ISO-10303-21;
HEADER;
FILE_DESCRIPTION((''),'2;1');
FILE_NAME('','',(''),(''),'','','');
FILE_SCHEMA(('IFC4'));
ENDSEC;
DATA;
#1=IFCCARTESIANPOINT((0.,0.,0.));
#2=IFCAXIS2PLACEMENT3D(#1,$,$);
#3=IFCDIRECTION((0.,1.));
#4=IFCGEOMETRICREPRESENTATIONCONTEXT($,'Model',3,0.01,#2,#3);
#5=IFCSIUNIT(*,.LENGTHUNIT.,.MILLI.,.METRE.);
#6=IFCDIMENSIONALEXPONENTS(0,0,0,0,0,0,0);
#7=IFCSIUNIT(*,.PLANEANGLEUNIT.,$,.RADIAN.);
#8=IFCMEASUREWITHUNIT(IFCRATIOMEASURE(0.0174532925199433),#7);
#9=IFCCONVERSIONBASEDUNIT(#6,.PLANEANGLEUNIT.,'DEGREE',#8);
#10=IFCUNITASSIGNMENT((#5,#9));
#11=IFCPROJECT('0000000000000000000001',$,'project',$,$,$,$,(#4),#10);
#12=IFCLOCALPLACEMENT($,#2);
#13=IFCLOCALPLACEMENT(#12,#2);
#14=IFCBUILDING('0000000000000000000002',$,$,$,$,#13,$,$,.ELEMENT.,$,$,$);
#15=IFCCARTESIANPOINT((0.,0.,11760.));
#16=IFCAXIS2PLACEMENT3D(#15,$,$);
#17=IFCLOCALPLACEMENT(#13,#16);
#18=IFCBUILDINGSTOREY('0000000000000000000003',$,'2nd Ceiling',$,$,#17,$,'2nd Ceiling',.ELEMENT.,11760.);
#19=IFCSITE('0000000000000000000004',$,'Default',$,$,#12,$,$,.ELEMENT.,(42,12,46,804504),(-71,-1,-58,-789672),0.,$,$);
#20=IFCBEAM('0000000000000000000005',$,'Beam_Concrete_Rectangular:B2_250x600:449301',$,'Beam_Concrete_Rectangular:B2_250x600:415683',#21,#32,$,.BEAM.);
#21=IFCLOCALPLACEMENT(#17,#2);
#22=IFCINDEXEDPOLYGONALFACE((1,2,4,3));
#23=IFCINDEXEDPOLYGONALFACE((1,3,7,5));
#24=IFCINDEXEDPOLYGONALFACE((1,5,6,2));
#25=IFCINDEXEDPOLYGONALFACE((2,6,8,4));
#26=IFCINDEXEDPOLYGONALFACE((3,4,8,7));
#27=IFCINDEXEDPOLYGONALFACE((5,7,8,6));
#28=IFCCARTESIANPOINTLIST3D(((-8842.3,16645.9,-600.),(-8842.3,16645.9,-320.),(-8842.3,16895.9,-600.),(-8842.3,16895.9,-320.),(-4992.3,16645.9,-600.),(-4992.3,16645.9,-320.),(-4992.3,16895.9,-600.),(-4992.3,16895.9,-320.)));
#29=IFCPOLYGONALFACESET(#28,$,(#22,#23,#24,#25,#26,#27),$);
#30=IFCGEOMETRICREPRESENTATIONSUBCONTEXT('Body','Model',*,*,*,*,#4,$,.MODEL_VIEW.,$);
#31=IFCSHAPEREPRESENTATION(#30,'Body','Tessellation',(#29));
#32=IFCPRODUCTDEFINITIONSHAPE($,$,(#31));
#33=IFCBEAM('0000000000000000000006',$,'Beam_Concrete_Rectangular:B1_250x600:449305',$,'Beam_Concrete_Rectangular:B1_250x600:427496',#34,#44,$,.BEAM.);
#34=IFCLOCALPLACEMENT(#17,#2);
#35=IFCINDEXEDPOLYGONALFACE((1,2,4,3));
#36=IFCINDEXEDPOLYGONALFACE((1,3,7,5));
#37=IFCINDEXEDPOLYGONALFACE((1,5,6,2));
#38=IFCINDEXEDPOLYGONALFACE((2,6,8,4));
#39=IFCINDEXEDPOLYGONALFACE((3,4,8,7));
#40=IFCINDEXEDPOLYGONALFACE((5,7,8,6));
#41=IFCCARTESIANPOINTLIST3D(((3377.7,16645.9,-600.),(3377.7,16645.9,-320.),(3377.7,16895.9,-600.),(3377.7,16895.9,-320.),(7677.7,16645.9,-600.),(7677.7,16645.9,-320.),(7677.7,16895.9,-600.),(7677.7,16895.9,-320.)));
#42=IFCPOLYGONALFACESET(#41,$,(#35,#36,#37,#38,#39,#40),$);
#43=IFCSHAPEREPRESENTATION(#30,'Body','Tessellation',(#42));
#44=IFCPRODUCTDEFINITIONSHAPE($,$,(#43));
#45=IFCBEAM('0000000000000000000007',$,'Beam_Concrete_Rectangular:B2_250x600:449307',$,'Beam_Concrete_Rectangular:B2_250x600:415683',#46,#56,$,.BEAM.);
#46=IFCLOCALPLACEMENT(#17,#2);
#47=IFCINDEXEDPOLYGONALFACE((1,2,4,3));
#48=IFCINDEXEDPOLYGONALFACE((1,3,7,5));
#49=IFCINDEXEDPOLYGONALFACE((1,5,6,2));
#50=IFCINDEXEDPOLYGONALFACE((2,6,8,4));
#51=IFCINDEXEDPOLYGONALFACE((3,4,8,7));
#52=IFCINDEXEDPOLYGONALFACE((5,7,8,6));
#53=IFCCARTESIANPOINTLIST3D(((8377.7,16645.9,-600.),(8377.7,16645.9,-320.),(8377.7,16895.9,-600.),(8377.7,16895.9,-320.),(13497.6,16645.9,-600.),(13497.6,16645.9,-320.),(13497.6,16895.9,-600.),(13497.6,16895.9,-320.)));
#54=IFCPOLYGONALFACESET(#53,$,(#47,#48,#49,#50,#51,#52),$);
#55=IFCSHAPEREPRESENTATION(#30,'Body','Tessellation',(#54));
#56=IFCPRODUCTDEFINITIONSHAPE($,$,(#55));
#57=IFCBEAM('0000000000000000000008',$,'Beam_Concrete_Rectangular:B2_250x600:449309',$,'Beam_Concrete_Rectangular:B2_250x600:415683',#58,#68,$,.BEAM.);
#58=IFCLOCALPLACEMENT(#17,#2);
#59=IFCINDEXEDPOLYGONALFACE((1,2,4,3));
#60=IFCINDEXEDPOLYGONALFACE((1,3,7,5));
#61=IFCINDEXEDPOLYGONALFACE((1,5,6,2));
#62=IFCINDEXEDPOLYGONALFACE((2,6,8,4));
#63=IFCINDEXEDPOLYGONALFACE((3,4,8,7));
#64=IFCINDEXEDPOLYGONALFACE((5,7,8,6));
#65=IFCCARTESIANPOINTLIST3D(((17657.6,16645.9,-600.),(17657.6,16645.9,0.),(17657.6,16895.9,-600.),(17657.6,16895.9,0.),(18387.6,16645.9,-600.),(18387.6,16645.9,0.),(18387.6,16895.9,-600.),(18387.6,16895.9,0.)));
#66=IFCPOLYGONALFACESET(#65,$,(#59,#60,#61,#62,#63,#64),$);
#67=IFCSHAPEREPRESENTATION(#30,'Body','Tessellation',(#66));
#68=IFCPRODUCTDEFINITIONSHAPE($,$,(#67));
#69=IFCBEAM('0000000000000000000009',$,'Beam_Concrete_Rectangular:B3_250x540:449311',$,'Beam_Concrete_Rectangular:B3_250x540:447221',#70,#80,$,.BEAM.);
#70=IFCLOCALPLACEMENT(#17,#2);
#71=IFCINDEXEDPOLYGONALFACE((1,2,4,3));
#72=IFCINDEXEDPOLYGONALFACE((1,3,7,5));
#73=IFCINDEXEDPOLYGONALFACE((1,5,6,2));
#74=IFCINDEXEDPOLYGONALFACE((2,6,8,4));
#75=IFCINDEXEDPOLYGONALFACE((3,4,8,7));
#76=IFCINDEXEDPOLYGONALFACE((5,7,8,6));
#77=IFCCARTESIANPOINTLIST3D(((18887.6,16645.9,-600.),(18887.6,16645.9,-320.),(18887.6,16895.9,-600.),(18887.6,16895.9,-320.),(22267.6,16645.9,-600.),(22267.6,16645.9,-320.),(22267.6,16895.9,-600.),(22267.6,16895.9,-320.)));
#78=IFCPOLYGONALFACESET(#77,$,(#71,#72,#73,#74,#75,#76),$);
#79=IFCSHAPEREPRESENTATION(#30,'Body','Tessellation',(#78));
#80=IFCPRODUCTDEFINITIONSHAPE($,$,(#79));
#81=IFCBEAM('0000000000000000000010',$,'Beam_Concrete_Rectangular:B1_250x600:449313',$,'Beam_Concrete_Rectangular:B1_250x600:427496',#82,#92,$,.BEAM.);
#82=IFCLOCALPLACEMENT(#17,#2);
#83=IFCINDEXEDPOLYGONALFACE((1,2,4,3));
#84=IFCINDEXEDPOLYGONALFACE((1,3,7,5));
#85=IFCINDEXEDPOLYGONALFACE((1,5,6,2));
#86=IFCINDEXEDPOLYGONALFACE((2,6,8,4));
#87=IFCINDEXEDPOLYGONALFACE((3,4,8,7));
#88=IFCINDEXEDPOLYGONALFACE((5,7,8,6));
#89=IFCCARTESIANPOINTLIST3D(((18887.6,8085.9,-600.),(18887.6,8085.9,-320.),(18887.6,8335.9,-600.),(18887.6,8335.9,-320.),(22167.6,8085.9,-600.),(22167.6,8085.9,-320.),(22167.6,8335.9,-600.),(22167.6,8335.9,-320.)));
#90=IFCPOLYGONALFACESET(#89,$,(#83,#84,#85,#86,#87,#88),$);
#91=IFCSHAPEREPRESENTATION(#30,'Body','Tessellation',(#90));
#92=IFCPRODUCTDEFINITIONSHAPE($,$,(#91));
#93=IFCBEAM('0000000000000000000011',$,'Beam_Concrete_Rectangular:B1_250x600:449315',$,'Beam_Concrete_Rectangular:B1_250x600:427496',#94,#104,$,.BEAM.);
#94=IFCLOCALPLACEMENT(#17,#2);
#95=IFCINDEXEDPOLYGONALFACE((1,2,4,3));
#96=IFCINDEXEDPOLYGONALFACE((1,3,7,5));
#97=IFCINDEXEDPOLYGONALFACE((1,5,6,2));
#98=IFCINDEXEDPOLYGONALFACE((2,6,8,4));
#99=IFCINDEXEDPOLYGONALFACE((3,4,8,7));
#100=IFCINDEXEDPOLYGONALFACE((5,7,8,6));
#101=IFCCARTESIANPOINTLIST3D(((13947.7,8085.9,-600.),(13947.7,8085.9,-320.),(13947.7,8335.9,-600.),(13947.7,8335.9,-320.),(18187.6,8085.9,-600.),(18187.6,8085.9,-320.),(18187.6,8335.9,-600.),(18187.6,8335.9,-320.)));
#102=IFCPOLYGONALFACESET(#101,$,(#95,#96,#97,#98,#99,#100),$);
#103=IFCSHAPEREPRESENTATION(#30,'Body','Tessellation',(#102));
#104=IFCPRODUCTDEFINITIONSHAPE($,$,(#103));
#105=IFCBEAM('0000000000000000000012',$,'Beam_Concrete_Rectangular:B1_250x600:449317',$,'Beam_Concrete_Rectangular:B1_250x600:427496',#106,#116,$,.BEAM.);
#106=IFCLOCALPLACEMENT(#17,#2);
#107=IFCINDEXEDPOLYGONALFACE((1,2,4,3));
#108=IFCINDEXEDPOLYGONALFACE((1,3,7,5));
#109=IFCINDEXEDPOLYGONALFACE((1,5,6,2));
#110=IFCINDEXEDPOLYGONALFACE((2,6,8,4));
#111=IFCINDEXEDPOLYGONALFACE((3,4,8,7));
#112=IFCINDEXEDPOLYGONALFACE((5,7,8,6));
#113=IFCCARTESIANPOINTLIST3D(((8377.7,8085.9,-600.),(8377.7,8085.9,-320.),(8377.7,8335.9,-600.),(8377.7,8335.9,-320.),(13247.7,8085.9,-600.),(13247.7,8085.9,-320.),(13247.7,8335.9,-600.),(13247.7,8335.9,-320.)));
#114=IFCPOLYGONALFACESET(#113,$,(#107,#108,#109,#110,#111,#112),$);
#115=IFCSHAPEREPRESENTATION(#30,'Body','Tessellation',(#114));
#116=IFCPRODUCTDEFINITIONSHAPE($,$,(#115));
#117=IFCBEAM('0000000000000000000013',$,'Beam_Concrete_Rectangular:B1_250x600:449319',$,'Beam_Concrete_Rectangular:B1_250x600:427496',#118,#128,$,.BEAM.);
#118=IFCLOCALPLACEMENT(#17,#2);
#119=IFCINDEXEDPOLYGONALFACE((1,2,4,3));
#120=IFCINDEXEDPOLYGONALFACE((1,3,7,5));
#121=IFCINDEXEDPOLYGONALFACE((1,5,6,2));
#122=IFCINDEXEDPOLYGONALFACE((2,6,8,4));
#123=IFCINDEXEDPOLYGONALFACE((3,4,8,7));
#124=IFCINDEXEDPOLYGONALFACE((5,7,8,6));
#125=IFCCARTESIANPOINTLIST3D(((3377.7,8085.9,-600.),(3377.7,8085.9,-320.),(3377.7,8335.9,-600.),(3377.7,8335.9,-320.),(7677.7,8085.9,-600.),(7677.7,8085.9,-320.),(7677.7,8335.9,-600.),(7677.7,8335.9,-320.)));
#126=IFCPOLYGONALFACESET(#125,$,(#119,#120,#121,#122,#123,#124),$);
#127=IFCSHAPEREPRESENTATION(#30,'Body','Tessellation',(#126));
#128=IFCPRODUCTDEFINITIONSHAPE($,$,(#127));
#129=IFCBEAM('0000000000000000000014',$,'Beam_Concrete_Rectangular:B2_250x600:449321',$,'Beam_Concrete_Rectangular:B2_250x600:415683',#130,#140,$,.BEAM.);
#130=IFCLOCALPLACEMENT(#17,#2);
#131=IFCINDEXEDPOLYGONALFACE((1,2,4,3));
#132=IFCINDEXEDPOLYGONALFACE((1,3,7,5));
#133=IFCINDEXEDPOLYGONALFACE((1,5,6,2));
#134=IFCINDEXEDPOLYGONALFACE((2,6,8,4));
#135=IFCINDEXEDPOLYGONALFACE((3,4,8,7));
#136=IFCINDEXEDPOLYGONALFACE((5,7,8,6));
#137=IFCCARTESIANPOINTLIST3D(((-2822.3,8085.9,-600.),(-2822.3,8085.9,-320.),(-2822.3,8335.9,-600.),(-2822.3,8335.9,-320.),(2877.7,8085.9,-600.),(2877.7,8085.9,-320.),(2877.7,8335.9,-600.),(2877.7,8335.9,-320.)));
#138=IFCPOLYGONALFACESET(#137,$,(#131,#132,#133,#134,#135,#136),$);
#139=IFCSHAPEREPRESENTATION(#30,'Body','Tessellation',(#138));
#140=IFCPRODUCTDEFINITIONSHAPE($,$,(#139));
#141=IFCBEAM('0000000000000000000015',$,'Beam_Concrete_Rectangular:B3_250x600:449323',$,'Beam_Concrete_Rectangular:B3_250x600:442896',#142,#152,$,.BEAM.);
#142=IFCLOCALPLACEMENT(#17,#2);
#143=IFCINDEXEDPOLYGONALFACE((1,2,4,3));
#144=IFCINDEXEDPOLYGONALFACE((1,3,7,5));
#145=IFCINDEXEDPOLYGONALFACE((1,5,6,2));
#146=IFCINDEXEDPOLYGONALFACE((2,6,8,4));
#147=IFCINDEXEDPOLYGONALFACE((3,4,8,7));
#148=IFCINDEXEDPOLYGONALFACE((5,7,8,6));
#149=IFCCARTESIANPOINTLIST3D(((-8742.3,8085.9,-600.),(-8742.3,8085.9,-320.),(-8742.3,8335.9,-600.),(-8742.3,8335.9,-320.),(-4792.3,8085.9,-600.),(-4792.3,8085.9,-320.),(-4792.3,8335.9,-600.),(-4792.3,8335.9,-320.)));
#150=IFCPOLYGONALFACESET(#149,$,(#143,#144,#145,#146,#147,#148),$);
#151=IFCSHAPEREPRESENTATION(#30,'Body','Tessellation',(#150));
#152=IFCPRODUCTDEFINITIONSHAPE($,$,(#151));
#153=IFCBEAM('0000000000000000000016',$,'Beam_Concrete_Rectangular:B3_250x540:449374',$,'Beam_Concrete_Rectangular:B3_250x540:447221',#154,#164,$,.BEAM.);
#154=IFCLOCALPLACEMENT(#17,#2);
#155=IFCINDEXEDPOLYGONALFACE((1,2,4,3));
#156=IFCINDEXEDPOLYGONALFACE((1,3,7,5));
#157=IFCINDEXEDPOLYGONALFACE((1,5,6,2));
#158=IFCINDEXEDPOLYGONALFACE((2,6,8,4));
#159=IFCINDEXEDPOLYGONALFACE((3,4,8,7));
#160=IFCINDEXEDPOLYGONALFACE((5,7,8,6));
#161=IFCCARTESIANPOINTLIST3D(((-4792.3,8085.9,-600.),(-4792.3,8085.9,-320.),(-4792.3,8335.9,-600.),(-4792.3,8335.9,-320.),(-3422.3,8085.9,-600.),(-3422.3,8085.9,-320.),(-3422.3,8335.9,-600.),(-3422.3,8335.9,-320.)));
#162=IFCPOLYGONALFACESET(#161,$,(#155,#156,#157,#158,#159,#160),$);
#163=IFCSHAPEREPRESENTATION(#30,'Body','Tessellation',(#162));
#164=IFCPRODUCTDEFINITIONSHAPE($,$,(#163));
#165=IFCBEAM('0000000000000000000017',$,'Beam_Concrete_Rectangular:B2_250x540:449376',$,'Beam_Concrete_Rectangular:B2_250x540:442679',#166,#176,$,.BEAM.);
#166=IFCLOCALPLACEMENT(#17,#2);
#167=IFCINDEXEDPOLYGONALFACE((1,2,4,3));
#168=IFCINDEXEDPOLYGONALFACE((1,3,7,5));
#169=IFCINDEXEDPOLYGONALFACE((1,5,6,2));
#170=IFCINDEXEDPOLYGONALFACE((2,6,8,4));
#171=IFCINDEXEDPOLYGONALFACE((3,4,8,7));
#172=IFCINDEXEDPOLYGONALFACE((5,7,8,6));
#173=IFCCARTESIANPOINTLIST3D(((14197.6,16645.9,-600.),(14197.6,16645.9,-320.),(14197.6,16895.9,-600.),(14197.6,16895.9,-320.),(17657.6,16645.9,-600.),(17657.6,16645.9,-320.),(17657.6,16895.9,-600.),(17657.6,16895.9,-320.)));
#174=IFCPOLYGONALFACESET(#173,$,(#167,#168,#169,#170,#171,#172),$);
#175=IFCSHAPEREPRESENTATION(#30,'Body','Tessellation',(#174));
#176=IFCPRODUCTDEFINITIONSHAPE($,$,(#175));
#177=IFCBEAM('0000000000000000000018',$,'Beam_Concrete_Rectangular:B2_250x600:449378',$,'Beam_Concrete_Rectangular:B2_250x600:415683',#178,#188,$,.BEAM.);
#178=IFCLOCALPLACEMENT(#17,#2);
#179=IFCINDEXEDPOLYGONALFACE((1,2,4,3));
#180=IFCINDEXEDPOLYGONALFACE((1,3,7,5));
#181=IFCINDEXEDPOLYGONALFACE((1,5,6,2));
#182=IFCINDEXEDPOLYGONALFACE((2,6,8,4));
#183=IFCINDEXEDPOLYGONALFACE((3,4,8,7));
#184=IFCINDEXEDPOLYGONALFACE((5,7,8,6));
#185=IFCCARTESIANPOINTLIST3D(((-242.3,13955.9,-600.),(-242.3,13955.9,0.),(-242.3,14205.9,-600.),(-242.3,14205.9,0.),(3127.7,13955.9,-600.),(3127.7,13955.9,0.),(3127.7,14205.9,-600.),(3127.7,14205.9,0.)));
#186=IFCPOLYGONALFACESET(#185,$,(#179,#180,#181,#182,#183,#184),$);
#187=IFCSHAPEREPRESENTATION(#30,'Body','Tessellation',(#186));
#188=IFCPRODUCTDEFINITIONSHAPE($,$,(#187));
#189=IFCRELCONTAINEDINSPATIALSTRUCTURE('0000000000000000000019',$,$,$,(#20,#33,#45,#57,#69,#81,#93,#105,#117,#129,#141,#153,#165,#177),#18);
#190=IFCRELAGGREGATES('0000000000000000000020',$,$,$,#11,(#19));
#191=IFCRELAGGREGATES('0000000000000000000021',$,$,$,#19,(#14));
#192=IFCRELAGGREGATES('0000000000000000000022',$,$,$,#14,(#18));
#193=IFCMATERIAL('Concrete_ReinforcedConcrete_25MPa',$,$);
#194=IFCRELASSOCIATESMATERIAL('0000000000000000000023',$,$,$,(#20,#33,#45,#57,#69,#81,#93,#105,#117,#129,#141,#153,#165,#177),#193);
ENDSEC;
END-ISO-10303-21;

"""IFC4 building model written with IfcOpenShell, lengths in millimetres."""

from ifc_helpers import new_model, entity, si_unit, converted_unit, direction, frame, frame_2d, origin, origin_2d_with_axis, place, context, subcontext, project, spatial, rectangle, extrude, material, element, save


model = new_model("IFC4")

# Units and contexts
model_context = context("Model", 3, precision=0.01, world=origin(), true_north=direction((0.0, 1.0)))
body_context = subcontext(model_context, "Body", "Model", "MODEL_VIEW")
ifc_project = project(units=[si_unit("LENGTHUNIT", "METRE", prefix="MILLI"), converted_unit("PLANEANGLEUNIT", "DEGREE", entity("IfcRatioMeasure", 0.0174532925199433), si_unit("PLANEANGLEUNIT", "RADIAN"), dimensions=[0, 0, 0, 0, 0, 0, 0])], contexts=[model_context])

# Site, building, storey
site_placement = place(None, origin())
site = spatial("IfcSite", under=ifc_project, at=site_placement, Name="Default", CompositionType="ELEMENT", RefLatitude=(42, 12, 46, 804504), RefLongitude=(-71, -1, -58, -789672), RefElevation=0.0)
building_placement = place(site_placement, origin())
building = spatial("IfcBuilding", under=site, at=building_placement, CompositionType="ELEMENT")
storey_placement = place(building_placement, frame((0.0, 0.0, 11760.0)))
storey = spatial("IfcBuildingStorey", under=building, at=storey_placement, Name="2nd Ceiling", LongName="2nd Ceiling", CompositionType="ELEMENT", Elevation=11760.0)

# Shared definitions
ifc_material = material(Name="Concrete_ReinforcedConcrete_25MPa")

# Beams
beam_1_placement = place(storey_placement, frame((-9042.3, 16645.9, 0.0)))
element("IfcBeam", 1, at=beam_1_placement, inside=storey, material=ifc_material, Name="Beam_Concrete_Rectangular:B2_250x600:449301", ObjectType="Beam_Concrete_Rectangular:B2_250x600:415683", PredefinedType="BEAM", context=body_context, shape_type="SweptSolid", body=[
    extrude(rectangle(XDim=280.0, YDim=250.0, at=origin_2d_with_axis()), frame((200.0, 125.0, -460.0), z_axis=(1.0, 0.0, 0.0), x_axis=(0.0, 0.0, -1.0)), (0.0, 0.0, 1.0), 3850.0),
])
beam_2_placement = place(storey_placement, frame((8027.7, 16895.9, 0.0), z_axis=(0.0, 0.0, 1.0), x_axis=(-1.0, 0.0, 0.0)))
element("IfcBeam", 2, at=beam_2_placement, inside=storey, material=ifc_material, Name="Beam_Concrete_Rectangular:B1_250x600:449305", ObjectType="Beam_Concrete_Rectangular:B1_250x600:427496", PredefinedType="BEAM", context=body_context, shape_type="SweptSolid", body=[
    extrude(rectangle(XDim=280.0, YDim=250.0, at=origin_2d_with_axis()), frame((350.0, 125.0, -460.0), z_axis=(1.0, 0.0, 0.0), x_axis=(0.0, 0.0, -1.0)), (0.0, 0.0, 1.0), 4300.0),
])
beam_3_placement = place(storey_placement, frame((13847.6, 16895.9, 0.0), z_axis=(0.0, 0.0, 1.0), x_axis=(-1.0, 0.0, 0.0)))
element("IfcBeam", 3, at=beam_3_placement, inside=storey, material=ifc_material, Name="Beam_Concrete_Rectangular:B2_250x600:449307", ObjectType="Beam_Concrete_Rectangular:B2_250x600:415683", PredefinedType="BEAM", context=body_context, shape_type="SweptSolid", body=[
    extrude(rectangle(XDim=280.0, YDim=250.0, at=origin_2d_with_axis()), frame((350.0, 125.0, -460.0), z_axis=(1.0, 0.0, 0.0), x_axis=(0.0, 0.0, -1.0)), (0.0, 0.0, 1.0), 5120.0),
])
beam_4_placement = place(storey_placement, frame((18637.6, 16895.9, 0.0), z_axis=(0.0, 0.0, 1.0), x_axis=(-1.0, 0.0, 0.0)))
element("IfcBeam", 4, at=beam_4_placement, inside=storey, material=ifc_material, Name="Beam_Concrete_Rectangular:B2_250x600:449309", ObjectType="Beam_Concrete_Rectangular:B2_250x600:415683", PredefinedType="BEAM", context=body_context, shape_type="SweptSolid", body=[
    extrude(rectangle(XDim=600.0, YDim=250.0, at=frame_2d((0.0, 0.0), x_axis=(1.0, 0.0))), frame((250.0, 125.0, -300.0), z_axis=(1.0, 0.0, 0.0), x_axis=(0.0, 0.0, -1.0)), (0.0, 0.0, 1.0), 730.0),
])
beam_5_placement = place(storey_placement, frame((22467.6, 16895.9, 0.0), z_axis=(0.0, 0.0, 1.0), x_axis=(-1.0, 0.0, 0.0)))
element("IfcBeam", 5, at=beam_5_placement, inside=storey, material=ifc_material, Name="Beam_Concrete_Rectangular:B3_250x540:449311", ObjectType="Beam_Concrete_Rectangular:B3_250x540:447221", PredefinedType="BEAM", context=body_context, shape_type="SweptSolid", body=[
    extrude(rectangle(XDim=280.0, YDim=250.0, at=frame_2d((0.0, 0.0), x_axis=(1.0, 0.0))), frame((200.0, 125.0, -460.0), z_axis=(1.0, 0.0, 0.0), x_axis=(0.0, 0.0, -1.0)), (0.0, 0.0, 1.0), 3380.0),
])
beam_6_placement = place(storey_placement, frame((18537.6, 8085.9, 0.0)))
element("IfcBeam", 6, at=beam_6_placement, inside=storey, material=ifc_material, Name="Beam_Concrete_Rectangular:B1_250x600:449313", ObjectType="Beam_Concrete_Rectangular:B1_250x600:427496", PredefinedType="BEAM", context=body_context, shape_type="SweptSolid", body=[
    extrude(rectangle(XDim=280.0, YDim=250.0, at=frame_2d((0.0, 0.0), x_axis=(1.0, 0.0))), frame((350.0, 125.0, -460.0), z_axis=(1.0, 0.0, 0.0), x_axis=(0.0, 0.0, -1.0)), (0.0, 0.0, 1.0), 3280.0),
])
beam_7_placement = place(storey_placement, frame((13597.7, 8085.9, 0.0)))
element("IfcBeam", 7, at=beam_7_placement, inside=storey, material=ifc_material, Name="Beam_Concrete_Rectangular:B1_250x600:449315", ObjectType="Beam_Concrete_Rectangular:B1_250x600:427496", PredefinedType="BEAM", context=body_context, shape_type="SweptSolid", body=[
    extrude(rectangle(XDim=280.0, YDim=250.0, at=frame_2d((0.0, 0.0), x_axis=(1.0, 0.0))), frame((350.0, 125.0, -460.0), z_axis=(1.0, 0.0, 0.0), x_axis=(0.0, 0.0, -1.0)), (0.0, 0.0, 1.0), 4240.0),
])
beam_8_placement = place(storey_placement, frame((8027.7, 8085.9, 0.0)))
element("IfcBeam", 8, at=beam_8_placement, inside=storey, material=ifc_material, Name="Beam_Concrete_Rectangular:B1_250x600:449317", ObjectType="Beam_Concrete_Rectangular:B1_250x600:427496", PredefinedType="BEAM", context=body_context, shape_type="SweptSolid", body=[
    extrude(rectangle(XDim=280.0, YDim=250.0, at=frame_2d((0.0, 0.0), x_axis=(1.0, 0.0))), frame((350.0, 125.0, -460.0), z_axis=(1.0, 0.0, 0.0), x_axis=(0.0, 0.0, -1.0)), (0.0, 0.0, 1.0), 4870.0),
])
beam_9_placement = place(storey_placement, frame((3127.7, 8085.9, 0.0)))
element("IfcBeam", 9, at=beam_9_placement, inside=storey, material=ifc_material, Name="Beam_Concrete_Rectangular:B1_250x600:449319", ObjectType="Beam_Concrete_Rectangular:B1_250x600:427496", PredefinedType="BEAM", context=body_context, shape_type="SweptSolid", body=[
    extrude(rectangle(XDim=280.0, YDim=250.0, at=frame_2d((0.0, 0.0), x_axis=(1.0, 0.0))), frame((250.0, 125.0, -460.0), z_axis=(1.0, 0.0, 0.0), x_axis=(0.0, 0.0, -1.0)), (0.0, 0.0, 1.0), 4300.0),
])
beam_10_placement = place(storey_placement, frame((-3122.3, 8085.9, 0.0)))
element("IfcBeam", 10, at=beam_10_placement, inside=storey, material=ifc_material, Name="Beam_Concrete_Rectangular:B2_250x600:449321", ObjectType="Beam_Concrete_Rectangular:B2_250x600:415683", PredefinedType="BEAM", context=body_context, shape_type="SweptSolid", body=[
    extrude(rectangle(XDim=280.0, YDim=250.0, at=frame_2d((0.0, 0.0), x_axis=(1.0, 0.0))), frame((300.0, 125.0, -460.0), z_axis=(1.0, 0.0, 0.0), x_axis=(0.0, 0.0, -1.0)), (0.0, 0.0, 1.0), 5700.0),
])
beam_11_placement = place(storey_placement, frame((-8992.3, 8085.9, 0.0)))
element("IfcBeam", 11, at=beam_11_placement, inside=storey, material=ifc_material, Name="Beam_Concrete_Rectangular:B3_250x600:449323", ObjectType="Beam_Concrete_Rectangular:B3_250x600:442896", PredefinedType="BEAM", context=body_context, shape_type="SweptSolid", body=[
    extrude(rectangle(XDim=280.0, YDim=250.0, at=frame_2d((0.0, 0.0), x_axis=(1.0, 0.0))), frame((250.0, 125.0, -460.0), z_axis=(1.0, 0.0, 0.0), x_axis=(0.0, 0.0, -1.0)), (0.0, 0.0, 1.0), 3950.0),
])
beam_12_placement = place(storey_placement, frame((-4792.3, 8085.9, 0.0)))
element("IfcBeam", 12, at=beam_12_placement, inside=storey, material=ifc_material, Name="Beam_Concrete_Rectangular:B3_250x540:449374", ObjectType="Beam_Concrete_Rectangular:B3_250x540:447221", PredefinedType="BEAM", context=body_context, shape_type="SweptSolid", body=[
    extrude(rectangle(XDim=280.0, YDim=250.0, at=frame_2d((0.0, 0.0), x_axis=(1.0, 0.0))), frame((0.0, 125.0, -460.0), z_axis=(1.0, 0.0, 0.0), x_axis=(0.0, 0.0, -1.0)), (0.0, 0.0, 1.0), 1370.0),
])
beam_13_placement = place(storey_placement, frame((17657.6, 16895.9, 0.0), z_axis=(0.0, 0.0, 1.0), x_axis=(-1.0, 0.0, 0.0)))
element("IfcBeam", 13, at=beam_13_placement, inside=storey, material=ifc_material, Name="Beam_Concrete_Rectangular:B2_250x540:449376", ObjectType="Beam_Concrete_Rectangular:B2_250x540:442679", PredefinedType="BEAM", context=body_context, shape_type="SweptSolid", body=[
    extrude(rectangle(XDim=280.0, YDim=250.0, at=frame_2d((0.0, 0.0), x_axis=(1.0, 0.0))), frame((0.0, 125.0, -460.0), z_axis=(1.0, 0.0, 0.0), x_axis=(0.0, 0.0, -1.0)), (0.0, 0.0, 1.0), 3460.0),
])
beam_14_placement = place(storey_placement, frame((3252.7, 14205.9, 0.0), z_axis=(0.0, 0.0, 1.0), x_axis=(-1.0, 0.0, 0.0)))
element("IfcBeam", 14, at=beam_14_placement, inside=storey, material=ifc_material, Name="Beam_Concrete_Rectangular:B2_250x600:449378", ObjectType="Beam_Concrete_Rectangular:B2_250x600:415683", PredefinedType="BEAM", context=body_context, shape_type="SweptSolid", body=[
    extrude(rectangle(XDim=600.0, YDim=250.0, at=frame_2d((0.0, 0.0), x_axis=(1.0, 0.0))), frame((125.0, 125.0, -300.0), z_axis=(1.0, 0.0, 0.0), x_axis=(0.0, 0.0, -1.0)), (0.0, 0.0, 1.0), 3370.0),
])

save(model, "model.ifc")
